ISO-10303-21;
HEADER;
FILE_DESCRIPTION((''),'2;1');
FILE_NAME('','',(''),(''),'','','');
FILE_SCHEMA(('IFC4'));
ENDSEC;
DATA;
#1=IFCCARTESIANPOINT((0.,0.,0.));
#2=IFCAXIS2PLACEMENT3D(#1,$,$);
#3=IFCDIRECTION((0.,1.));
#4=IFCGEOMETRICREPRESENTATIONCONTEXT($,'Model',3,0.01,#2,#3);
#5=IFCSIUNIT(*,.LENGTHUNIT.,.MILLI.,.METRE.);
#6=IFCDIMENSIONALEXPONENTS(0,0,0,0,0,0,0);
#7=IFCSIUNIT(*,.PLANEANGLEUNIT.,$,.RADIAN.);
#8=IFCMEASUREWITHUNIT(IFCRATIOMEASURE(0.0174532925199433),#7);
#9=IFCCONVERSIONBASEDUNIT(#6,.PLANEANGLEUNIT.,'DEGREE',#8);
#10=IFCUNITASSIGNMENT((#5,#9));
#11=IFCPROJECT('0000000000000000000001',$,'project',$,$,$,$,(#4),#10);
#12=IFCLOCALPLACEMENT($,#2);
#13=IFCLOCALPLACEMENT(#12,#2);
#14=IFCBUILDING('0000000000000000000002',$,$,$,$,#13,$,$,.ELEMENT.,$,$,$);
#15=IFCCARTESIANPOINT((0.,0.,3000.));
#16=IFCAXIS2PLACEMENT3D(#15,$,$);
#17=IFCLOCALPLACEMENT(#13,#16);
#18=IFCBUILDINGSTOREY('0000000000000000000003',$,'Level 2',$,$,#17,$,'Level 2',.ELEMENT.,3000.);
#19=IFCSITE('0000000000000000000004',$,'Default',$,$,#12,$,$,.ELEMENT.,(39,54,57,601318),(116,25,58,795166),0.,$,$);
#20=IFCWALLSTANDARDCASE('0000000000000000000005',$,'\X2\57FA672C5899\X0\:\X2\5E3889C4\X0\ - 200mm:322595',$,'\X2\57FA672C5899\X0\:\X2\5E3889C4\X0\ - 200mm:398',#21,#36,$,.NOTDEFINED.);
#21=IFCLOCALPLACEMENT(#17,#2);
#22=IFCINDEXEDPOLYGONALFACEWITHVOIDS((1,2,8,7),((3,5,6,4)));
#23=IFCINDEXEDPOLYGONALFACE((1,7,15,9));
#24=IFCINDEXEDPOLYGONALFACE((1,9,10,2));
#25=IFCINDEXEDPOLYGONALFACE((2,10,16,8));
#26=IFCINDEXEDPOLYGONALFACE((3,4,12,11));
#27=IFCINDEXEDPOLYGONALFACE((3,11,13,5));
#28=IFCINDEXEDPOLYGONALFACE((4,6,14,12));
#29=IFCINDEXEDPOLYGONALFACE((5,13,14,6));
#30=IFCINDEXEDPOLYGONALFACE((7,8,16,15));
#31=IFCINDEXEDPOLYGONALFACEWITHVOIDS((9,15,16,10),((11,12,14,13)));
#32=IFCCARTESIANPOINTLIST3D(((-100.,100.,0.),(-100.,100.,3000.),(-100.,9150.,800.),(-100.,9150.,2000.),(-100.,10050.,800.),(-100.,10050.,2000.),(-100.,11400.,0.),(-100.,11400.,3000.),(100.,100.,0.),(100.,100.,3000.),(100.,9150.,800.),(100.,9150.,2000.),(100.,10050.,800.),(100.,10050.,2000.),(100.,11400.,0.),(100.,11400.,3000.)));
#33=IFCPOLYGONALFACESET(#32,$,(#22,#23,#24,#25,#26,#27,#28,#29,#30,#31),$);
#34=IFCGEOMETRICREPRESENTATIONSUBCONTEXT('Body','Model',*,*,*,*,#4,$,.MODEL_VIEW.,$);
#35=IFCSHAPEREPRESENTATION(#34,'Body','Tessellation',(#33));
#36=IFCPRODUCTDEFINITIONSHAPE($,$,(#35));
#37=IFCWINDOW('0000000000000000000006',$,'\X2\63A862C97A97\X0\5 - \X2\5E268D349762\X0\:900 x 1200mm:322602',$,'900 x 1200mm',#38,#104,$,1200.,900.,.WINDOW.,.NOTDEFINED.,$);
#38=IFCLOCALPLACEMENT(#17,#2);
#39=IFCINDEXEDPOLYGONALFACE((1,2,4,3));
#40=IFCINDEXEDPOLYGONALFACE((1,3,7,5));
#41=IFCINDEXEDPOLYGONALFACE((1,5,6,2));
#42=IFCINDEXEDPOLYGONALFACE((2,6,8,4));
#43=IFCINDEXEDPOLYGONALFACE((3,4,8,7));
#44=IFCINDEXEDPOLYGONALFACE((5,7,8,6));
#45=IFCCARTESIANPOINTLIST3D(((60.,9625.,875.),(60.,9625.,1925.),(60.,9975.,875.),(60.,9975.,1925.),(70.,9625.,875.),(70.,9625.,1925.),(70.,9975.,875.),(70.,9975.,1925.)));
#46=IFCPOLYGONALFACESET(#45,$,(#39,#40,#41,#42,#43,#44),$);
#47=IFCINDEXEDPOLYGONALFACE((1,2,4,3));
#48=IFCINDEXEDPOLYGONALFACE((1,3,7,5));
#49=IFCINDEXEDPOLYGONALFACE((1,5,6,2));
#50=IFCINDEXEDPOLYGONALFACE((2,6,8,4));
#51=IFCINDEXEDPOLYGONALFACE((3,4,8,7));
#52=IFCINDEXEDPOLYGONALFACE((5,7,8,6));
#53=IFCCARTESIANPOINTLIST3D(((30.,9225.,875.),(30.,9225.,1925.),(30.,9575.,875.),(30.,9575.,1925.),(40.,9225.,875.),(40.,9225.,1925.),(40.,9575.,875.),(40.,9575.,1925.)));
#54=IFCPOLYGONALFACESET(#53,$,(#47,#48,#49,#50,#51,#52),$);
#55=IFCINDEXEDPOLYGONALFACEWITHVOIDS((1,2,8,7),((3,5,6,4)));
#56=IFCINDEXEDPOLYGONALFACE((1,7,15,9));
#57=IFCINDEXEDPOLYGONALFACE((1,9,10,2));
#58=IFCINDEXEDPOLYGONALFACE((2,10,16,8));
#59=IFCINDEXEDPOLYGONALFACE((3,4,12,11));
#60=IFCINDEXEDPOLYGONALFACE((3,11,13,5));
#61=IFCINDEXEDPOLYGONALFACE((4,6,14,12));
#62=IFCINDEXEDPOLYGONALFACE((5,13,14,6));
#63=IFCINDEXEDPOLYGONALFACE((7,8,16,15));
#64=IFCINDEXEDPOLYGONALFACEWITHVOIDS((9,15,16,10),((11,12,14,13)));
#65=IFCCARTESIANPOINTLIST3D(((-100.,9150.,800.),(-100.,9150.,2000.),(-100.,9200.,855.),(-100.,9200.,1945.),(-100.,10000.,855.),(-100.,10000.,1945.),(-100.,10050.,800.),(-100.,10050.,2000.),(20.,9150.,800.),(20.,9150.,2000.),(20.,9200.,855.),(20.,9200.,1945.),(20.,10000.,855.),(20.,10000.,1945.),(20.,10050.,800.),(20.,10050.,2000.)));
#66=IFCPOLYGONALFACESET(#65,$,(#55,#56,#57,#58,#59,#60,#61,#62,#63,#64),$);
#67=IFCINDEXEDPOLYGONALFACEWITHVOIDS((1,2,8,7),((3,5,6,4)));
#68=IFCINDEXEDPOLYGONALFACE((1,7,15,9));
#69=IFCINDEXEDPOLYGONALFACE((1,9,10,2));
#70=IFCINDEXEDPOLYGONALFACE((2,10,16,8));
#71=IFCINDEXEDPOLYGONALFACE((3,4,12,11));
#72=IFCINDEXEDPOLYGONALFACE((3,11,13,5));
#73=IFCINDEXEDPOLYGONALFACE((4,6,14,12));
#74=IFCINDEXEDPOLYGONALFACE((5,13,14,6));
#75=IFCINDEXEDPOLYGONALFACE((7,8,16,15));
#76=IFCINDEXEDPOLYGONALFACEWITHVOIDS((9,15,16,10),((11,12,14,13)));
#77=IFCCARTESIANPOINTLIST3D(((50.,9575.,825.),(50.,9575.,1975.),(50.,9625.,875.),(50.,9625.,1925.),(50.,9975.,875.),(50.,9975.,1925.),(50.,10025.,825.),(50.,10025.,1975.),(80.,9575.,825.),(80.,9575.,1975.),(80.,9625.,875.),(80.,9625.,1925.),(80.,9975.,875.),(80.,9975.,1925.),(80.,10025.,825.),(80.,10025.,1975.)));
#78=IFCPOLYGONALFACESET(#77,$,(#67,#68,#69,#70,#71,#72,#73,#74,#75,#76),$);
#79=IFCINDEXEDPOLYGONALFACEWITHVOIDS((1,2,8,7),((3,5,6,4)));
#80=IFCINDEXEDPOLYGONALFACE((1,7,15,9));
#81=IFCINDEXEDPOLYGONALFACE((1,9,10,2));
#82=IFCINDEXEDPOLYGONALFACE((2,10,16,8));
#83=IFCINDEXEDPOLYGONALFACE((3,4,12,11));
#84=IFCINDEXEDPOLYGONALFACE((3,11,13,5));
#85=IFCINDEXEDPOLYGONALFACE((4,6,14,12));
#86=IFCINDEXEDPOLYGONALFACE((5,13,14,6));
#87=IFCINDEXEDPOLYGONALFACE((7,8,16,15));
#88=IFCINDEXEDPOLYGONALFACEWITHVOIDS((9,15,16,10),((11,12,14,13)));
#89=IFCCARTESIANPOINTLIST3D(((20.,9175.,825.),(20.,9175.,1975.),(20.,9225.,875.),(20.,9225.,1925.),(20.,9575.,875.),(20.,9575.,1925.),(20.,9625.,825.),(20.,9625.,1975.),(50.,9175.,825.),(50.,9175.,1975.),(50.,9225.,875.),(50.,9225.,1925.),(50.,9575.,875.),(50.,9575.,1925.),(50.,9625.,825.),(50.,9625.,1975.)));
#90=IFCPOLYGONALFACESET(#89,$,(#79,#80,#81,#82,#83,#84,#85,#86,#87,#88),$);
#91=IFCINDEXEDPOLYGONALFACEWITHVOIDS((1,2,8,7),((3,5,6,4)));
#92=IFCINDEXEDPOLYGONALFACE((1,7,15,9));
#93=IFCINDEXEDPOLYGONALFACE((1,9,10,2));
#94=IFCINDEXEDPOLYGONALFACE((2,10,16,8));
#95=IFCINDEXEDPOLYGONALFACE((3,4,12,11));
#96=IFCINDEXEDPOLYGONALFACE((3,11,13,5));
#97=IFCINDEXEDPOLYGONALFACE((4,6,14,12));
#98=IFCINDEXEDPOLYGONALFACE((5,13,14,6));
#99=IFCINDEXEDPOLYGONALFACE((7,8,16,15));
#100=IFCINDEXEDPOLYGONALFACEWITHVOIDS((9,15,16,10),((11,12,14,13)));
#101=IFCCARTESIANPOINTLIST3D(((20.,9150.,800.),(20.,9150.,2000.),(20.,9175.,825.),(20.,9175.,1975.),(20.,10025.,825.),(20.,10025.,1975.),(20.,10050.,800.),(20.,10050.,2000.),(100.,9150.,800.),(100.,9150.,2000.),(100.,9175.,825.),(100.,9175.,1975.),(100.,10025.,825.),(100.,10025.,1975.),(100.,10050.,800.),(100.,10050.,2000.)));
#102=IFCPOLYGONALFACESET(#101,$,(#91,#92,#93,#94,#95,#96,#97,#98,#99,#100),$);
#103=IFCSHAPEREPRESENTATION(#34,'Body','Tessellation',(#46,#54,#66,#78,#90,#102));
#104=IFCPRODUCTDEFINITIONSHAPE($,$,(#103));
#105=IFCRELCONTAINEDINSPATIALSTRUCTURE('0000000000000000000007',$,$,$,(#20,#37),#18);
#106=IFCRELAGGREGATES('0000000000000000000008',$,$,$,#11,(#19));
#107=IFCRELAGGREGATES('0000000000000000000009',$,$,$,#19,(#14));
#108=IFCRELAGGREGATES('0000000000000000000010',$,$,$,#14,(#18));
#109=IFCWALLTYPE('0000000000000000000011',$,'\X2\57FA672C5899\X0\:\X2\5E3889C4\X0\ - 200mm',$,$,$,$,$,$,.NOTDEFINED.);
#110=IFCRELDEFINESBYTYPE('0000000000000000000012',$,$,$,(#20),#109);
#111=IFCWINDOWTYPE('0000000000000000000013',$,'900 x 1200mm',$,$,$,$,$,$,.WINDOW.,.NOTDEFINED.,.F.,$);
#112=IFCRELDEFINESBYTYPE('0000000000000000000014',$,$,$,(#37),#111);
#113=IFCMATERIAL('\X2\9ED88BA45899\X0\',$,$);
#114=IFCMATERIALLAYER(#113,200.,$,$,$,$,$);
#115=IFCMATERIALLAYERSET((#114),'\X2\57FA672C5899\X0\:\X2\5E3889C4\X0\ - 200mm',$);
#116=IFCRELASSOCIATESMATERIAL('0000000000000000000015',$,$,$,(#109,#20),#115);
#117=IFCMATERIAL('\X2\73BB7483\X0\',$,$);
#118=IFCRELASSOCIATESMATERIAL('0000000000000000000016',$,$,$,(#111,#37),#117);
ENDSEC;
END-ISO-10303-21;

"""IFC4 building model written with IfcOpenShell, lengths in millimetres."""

from ifc_helpers import new_model, entity, si_unit, converted_unit, direction, frame, frame_2d, origin, origin_2d_with_axis, place, context, subcontext, project, spatial, polyline, rectangle, outline, extrude, source, transform, mapped, material, layer, layer_set, layer_usage, type_object, type_shapes, element, fill, save


model = new_model("IFC4")

# Units and contexts
model_context = context("Model", 3, precision=0.01, world=origin(), true_north=direction((0.0, 1.0)))
body_context = subcontext(model_context, "Body", "Model", "MODEL_VIEW")
ifc_project = project(units=[si_unit("LENGTHUNIT", "METRE", prefix="MILLI"), converted_unit("PLANEANGLEUNIT", "DEGREE", entity("IfcRatioMeasure", 0.0174532925199433), si_unit("PLANEANGLEUNIT", "RADIAN"), dimensions=[0, 0, 0, 0, 0, 0, 0])], contexts=[model_context])

# Site, building, storey
site_placement = place(None, origin())
site = spatial("IfcSite", under=ifc_project, at=site_placement, Name="Default", CompositionType="ELEMENT", RefLatitude=(39, 54, 57, 601318), RefLongitude=(116, 25, 58, 795166), RefElevation=0.0)
building_placement = place(site_placement, origin())
building = spatial("IfcBuilding", under=site, at=building_placement, CompositionType="ELEMENT")
storey_placement = place(building_placement, frame((0.0, 0.0, 3000.0)))
storey = spatial("IfcBuildingStorey", under=building, at=storey_placement, Name="Level 2", LongName="Level 2", CompositionType="ELEMENT", Elevation=3000.0)

# Shared definitions
ifc_material_1 = material(Name="默认墙")
ifc_layer_1 = layer(ifc_material_1, 200.0)
ifc_layer_set_1 = layer_set([ifc_layer_1], Name="基本墙:常规 - 200mm")
wall_type = type_object("IfcWallType", Name="基本墙:常规 - 200mm", PredefinedType="NOTDEFINED", material=ifc_layer_set_1)

# Shared definitions
ifc_material_2 = material(Name="玻璃")
window_type_1 = type_object("IfcWindowType", Name="900 x 1200mm", ParameterTakesPrecedence=False, PartitioningType="NOTDEFINED", PredefinedType="WINDOW", material=ifc_material_2)
shared_shape_1 = source(origin(), body_context, "Body", "SweptSolid", [
    extrude(rectangle(XDim=10.0, YDim=350.0, at=origin_2d_with_axis()), frame((250.0, 165.0, 75.0), z_axis=(0.0, 0.0, 1.0), x_axis=(0.0, -1.0, 0.0)), (0.0, 0.0, 1.0), 1050.0),
    extrude(rectangle(XDim=10.0, YDim=350.0, at=frame_2d((0.0, 0.0), x_axis=(1.0, 0.0))), frame((650.0, 135.0, 75.0), z_axis=(0.0, 0.0, 1.0), x_axis=(0.0, -1.0, 0.0)), (0.0, 0.0, 1.0), 1050.0),
    extrude(outline(polyline([(-450.0, -600.0), (450.0, -600.0), (450.0, 600.0), (-450.0, 600.0), (-450.0, -600.0)]), holes=[polyline([(400.0, -545.0), (-400.0, -545.0), (-400.0, 545.0), (400.0, 545.0), (400.0, -545.0)])]), frame((450.0, 0.0, 600.0), z_axis=(0.0, 1.0, 0.0), x_axis=(1.0, 0.0, 0.0)), (0.0, 0.0, 1.0), 120.0),
    extrude(outline(polyline([(-225.0, -575.0), (225.0, -575.0), (225.0, 575.0), (-225.0, 575.0), (-225.0, -575.0)]), holes=[polyline([(-175.0, -525.0), (-175.0, 525.0), (175.0, 525.0), (175.0, -525.0), (-175.0, -525.0)])]), frame((250.0, 150.0, 600.0), z_axis=(0.0, 1.0, 0.0), x_axis=(-1.0, 0.0, 0.0)), (0.0, 0.0, 1.0), 30.0),
    extrude(outline(polyline([(-225.0, -575.0), (225.0, -575.0), (225.0, 575.0), (-225.0, 575.0), (-225.0, -575.0)]), holes=[polyline([(-175.0, -525.0), (-175.0, 525.0), (175.0, 525.0), (175.0, -525.0), (-175.0, -525.0)])]), frame((650.0, 120.0, 600.0), z_axis=(0.0, 1.0, 0.0), x_axis=(1.0, 0.0, 0.0)), (0.0, 0.0, 1.0), 30.0),
    extrude(outline(polyline([(-450.0, -600.0), (450.0, -600.0), (450.0, 600.0), (-450.0, 600.0), (-450.0, -600.0)]), holes=[polyline([(-425.0, 575.0), (425.0, 575.0), (425.0, -575.0), (-425.0, -575.0), (-425.0, 575.0)])]), frame((450.0, 120.0, 600.0), z_axis=(0.0, 1.0, 0.0), x_axis=(1.0, 0.0, 0.0)), (0.0, 0.0, 1.0), 80.0),
])
type_shapes(window_type_1, [shared_shape_1])

# Wall, opening, window
ifc_layer_usage_1 = layer_usage(ifc_layer_set_1, "AXIS2", "NEGATIVE", 100.0)
wall_1_placement = place(storey_placement, frame((0.0, 100.0, 0.0), z_axis=(0.0, 0.0, 1.0), x_axis=(0.0, 1.0, 0.0)))
wall_1 = element("IfcWallStandardCase", 1, at=wall_1_placement, inside=storey, type_object=wall_type, material=ifc_layer_usage_1, Name="基本墙:常规 - 200mm:322595", ObjectType="基本墙:常规 - 200mm:398", PredefinedType="NOTDEFINED", context=body_context, shape_type="SweptSolid", body=[
    extrude(rectangle(XDim=11300.0, YDim=200.0, at=frame_2d((5650.0, 0.0), x_axis=(-1.0, 0.0))), origin(), (0.0, 0.0, 1.0), 3000.0),
])
opening_1_placement = place(wall_1_placement, frame((9950.0, 100.0, 800.0)))
opening_1 = element("IfcOpeningElement", 2, at=opening_1_placement, cuts=wall_1, ObjectType="Opening", PredefinedType="OPENING", context=body_context, shape_type="SweptSolid", body=[
    extrude(rectangle(XDim=1200.0, YDim=900.0, at=frame_2d((600.0, 450.0), x_axis=(-1.0, 0.0))), frame((0.0, 0.0, 0.0), z_axis=(0.0, -1.0, 0.0), x_axis=(0.0, 0.0, 1.0)), (0.0, 0.0, 1.0), 200.0),
])
window_1_placement = place(opening_1_placement, frame((0.0, 0.0, 0.0), z_axis=(0.0, 0.0, 1.0), x_axis=(-1.0, 0.0, 0.0)))
window_1 = element("IfcWindow", 3, at=window_1_placement, inside=storey, type_object=window_type_1, material=ifc_material_2, Name="推拉窗5 - 带贴面:900 x 1200mm:322602", ObjectType="900 x 1200mm", OverallHeight=1200.0, OverallWidth=900.0, PartitioningType="NOTDEFINED", PredefinedType="WINDOW", context=body_context, shape_type="MappedRepresentation", body=[
    mapped(shared_shape_1, transform((0.0, 0.0, 0.0), scale=1.0)),
])
fill(opening_1, window_1)

save(model, "model.ifc")
